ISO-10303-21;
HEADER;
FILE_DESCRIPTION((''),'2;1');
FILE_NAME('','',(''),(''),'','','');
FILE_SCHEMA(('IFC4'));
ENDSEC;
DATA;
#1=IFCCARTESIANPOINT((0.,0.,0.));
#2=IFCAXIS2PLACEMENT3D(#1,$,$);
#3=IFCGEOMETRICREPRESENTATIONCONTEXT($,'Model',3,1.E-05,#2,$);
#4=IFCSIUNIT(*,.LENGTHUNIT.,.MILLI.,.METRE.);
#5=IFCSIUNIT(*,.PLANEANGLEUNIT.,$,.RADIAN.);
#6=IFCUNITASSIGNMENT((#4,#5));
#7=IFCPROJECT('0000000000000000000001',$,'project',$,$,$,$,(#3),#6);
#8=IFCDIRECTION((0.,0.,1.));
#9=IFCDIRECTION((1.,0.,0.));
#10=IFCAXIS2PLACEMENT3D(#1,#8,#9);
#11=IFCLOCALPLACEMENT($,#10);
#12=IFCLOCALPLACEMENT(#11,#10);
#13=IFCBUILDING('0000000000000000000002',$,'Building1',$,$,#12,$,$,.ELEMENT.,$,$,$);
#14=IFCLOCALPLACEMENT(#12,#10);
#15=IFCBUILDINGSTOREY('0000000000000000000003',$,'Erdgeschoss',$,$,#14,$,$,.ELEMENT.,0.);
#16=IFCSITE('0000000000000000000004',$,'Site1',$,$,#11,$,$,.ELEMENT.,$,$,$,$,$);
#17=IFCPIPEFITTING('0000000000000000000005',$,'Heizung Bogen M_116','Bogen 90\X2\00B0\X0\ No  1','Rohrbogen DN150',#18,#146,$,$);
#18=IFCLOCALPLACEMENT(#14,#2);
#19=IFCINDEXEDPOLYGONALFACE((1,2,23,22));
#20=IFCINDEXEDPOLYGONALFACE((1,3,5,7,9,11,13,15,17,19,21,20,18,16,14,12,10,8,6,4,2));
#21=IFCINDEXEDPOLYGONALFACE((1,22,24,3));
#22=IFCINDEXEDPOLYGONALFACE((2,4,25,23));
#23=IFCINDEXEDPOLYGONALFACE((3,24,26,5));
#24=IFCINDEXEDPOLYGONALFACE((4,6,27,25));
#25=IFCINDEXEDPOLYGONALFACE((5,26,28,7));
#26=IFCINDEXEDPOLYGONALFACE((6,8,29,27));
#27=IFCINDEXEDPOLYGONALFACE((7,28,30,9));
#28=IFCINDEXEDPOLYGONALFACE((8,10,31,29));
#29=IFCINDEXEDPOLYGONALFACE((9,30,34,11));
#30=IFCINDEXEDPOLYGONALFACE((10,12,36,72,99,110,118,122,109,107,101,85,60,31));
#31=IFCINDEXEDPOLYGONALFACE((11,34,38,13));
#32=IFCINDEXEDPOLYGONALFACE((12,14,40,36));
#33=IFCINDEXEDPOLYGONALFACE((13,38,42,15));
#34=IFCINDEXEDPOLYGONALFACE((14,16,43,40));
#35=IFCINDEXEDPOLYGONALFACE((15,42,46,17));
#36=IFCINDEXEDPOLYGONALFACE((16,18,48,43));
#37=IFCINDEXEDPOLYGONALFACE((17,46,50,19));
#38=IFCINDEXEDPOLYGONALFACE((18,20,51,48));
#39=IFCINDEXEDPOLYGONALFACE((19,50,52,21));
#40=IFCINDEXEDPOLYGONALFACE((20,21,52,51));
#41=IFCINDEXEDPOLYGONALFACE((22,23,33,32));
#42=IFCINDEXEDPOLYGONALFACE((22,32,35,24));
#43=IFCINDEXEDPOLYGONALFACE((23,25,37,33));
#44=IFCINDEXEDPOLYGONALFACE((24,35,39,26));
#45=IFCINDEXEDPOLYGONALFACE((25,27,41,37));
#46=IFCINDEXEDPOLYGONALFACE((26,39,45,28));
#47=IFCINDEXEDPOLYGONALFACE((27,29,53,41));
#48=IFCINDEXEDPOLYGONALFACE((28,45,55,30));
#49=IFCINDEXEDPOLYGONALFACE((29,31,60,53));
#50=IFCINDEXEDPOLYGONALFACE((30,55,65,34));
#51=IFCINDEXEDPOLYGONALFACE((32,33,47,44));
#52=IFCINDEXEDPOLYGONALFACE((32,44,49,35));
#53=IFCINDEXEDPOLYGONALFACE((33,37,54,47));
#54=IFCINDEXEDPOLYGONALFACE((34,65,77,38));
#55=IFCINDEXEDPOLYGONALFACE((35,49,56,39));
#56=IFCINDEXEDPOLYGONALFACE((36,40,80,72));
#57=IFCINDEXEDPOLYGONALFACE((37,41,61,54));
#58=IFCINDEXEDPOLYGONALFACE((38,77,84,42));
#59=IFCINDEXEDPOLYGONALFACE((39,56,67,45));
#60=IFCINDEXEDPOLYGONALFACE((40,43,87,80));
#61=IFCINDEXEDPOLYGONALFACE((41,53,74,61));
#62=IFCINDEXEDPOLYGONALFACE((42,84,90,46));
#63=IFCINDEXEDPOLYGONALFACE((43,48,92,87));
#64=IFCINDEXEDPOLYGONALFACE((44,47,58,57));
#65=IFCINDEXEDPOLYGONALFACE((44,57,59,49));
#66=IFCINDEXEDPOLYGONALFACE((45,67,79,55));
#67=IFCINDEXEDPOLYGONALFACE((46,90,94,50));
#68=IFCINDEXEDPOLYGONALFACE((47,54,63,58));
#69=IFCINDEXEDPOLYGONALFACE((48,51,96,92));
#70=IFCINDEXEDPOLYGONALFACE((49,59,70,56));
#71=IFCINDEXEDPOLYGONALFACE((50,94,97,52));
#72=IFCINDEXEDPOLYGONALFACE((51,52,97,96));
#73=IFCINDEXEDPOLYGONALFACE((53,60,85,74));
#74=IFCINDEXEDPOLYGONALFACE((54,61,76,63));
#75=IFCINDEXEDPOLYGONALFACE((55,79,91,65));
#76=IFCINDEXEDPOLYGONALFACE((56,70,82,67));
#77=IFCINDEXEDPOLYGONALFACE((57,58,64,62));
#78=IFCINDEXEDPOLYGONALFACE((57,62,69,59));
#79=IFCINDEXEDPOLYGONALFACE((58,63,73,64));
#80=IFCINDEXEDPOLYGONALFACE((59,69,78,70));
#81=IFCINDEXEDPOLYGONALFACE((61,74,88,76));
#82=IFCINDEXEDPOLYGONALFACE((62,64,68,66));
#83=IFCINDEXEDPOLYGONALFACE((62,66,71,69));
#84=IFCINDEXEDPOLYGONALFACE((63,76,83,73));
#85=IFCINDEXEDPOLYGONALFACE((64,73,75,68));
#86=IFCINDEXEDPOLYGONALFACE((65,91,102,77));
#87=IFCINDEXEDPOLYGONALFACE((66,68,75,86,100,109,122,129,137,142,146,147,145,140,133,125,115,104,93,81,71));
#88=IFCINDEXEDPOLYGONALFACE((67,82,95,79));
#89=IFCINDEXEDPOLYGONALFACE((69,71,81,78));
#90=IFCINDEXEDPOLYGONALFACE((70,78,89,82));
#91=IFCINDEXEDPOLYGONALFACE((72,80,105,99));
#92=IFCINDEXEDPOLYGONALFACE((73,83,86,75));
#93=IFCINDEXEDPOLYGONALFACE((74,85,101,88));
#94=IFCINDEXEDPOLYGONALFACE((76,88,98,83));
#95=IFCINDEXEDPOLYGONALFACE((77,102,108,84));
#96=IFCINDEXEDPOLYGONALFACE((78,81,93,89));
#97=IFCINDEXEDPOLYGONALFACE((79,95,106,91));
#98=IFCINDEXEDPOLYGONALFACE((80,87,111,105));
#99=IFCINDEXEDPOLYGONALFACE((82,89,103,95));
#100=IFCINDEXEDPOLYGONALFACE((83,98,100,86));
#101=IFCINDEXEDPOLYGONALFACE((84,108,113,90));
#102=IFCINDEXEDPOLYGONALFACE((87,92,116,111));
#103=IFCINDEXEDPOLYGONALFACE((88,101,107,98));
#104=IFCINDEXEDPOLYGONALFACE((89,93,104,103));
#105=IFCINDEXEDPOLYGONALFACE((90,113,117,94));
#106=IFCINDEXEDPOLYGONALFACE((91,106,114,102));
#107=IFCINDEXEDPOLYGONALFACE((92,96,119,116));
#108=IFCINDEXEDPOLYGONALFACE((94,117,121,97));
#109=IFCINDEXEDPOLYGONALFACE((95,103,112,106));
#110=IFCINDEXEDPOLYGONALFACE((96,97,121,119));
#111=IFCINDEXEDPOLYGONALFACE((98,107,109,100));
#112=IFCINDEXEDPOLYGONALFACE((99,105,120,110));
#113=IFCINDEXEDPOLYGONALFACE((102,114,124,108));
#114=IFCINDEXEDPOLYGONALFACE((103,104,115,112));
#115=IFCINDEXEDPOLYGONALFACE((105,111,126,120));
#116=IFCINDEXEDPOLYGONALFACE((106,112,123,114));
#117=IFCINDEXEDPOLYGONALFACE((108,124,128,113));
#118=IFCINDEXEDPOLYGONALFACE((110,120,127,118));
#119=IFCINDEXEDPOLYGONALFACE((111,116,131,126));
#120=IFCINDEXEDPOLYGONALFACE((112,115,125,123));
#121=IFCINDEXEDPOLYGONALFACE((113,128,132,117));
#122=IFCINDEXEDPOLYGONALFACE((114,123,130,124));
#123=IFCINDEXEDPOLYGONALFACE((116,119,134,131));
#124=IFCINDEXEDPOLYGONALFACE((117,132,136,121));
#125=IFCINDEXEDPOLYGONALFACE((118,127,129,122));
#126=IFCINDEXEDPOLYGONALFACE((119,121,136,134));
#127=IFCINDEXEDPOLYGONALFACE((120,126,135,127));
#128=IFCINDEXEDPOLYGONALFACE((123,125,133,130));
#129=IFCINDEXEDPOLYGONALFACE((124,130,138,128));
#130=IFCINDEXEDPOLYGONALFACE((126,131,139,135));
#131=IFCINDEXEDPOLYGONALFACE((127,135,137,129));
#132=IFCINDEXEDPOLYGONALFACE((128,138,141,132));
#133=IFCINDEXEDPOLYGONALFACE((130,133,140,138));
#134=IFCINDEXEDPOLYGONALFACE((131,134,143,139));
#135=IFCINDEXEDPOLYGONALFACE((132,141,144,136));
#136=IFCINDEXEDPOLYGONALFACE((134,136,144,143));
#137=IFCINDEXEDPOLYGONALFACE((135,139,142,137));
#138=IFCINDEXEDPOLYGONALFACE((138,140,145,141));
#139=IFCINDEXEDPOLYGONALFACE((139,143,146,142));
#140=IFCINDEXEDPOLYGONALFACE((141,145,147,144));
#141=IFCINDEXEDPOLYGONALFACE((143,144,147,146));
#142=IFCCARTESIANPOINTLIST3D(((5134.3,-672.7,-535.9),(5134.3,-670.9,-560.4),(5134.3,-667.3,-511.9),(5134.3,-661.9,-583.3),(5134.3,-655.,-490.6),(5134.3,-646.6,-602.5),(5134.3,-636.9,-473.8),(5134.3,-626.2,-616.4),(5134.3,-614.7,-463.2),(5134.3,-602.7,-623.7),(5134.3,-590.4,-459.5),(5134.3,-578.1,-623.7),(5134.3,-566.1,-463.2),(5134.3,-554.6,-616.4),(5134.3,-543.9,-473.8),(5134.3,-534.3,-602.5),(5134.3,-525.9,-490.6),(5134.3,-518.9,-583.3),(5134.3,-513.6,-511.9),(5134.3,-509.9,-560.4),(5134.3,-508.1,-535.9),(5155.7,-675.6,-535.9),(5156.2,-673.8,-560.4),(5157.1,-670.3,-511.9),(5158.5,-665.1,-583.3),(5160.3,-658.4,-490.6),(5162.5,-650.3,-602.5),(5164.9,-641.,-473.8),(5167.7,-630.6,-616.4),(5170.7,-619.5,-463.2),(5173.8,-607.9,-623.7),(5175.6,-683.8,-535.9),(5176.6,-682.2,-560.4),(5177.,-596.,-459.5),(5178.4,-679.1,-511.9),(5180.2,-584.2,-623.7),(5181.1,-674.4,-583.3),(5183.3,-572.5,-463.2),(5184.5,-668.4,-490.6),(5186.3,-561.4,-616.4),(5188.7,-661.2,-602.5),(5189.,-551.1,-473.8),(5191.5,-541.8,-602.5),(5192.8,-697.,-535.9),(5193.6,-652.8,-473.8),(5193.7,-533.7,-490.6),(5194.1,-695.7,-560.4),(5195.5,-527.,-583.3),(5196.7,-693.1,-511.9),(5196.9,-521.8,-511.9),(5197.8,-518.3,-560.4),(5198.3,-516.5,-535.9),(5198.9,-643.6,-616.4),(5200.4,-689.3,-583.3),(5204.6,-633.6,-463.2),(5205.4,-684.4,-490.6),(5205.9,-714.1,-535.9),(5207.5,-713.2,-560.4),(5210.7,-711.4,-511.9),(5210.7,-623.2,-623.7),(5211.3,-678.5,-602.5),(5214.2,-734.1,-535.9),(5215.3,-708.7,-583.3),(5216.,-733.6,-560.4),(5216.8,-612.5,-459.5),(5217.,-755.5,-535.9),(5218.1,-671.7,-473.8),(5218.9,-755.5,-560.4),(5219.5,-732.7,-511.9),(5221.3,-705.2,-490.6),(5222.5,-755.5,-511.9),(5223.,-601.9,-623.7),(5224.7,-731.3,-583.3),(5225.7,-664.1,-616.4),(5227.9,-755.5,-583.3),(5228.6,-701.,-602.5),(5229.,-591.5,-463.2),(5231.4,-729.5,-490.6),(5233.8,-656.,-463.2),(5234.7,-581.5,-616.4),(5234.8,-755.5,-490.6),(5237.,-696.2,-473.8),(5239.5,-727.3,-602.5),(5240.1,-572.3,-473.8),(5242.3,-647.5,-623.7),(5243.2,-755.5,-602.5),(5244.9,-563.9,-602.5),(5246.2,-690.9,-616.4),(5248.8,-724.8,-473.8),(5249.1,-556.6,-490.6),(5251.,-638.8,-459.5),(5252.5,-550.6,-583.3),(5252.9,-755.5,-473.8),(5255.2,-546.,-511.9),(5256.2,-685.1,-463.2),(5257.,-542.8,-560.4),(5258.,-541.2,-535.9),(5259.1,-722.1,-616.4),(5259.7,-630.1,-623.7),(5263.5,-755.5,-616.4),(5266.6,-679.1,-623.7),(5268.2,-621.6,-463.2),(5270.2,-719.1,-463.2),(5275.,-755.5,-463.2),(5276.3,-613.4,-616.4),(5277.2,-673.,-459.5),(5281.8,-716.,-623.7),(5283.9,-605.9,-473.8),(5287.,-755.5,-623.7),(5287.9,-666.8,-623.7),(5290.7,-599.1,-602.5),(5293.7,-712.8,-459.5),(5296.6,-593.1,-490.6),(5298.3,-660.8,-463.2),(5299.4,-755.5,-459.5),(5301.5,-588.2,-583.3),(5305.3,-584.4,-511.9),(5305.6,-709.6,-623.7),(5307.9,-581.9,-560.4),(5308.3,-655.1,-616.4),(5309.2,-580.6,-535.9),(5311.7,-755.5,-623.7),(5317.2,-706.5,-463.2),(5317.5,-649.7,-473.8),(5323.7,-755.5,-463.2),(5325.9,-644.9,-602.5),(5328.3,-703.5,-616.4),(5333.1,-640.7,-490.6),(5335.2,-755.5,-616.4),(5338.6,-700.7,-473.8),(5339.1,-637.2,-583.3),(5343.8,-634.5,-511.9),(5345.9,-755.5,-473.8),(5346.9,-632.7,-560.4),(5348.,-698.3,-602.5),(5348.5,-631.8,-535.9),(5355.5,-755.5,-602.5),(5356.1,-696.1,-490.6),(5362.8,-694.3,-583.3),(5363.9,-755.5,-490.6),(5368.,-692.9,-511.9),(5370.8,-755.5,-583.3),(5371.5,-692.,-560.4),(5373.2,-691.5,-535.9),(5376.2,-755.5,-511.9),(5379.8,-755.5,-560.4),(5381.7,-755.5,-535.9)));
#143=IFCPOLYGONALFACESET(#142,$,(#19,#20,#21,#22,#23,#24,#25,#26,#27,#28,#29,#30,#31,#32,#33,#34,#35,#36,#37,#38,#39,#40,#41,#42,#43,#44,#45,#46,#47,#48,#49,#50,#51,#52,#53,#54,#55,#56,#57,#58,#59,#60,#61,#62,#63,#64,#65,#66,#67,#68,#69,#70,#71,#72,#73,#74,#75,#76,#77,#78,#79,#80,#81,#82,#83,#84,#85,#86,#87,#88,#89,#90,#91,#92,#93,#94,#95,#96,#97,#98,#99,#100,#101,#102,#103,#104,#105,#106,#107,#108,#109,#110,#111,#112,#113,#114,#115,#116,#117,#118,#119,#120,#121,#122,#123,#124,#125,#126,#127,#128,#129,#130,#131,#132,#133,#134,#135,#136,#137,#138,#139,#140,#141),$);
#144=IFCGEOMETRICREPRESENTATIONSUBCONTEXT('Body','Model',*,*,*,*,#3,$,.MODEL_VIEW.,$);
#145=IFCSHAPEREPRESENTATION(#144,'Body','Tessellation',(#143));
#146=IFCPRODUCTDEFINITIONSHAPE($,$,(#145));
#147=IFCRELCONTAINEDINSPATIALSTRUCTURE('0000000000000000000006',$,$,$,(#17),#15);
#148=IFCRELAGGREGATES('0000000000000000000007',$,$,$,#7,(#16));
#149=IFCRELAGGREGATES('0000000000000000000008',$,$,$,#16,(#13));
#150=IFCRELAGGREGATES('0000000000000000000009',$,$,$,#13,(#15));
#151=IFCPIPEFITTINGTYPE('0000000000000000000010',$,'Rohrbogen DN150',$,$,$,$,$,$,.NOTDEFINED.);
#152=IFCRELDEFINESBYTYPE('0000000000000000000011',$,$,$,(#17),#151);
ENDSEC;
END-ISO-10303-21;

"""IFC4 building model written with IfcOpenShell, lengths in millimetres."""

from ifc_helpers import new_model, entity, si_unit, frame, origin, origin_with_axes, place, context, subcontext, project, spatial, source, transform, mapped, type_object, element, save


model = new_model("IFC4")

# Units and contexts
model_context = context("Model", 3, precision=1e-05, world=origin())
body_context = subcontext(model_context, "Body", "Model", "MODEL_VIEW")
ifc_project = project(units=[si_unit("LENGTHUNIT", "METRE", prefix="MILLI"), si_unit("PLANEANGLEUNIT", "RADIAN")], contexts=[model_context])

# Site, building, storey
site_placement = place(None, origin_with_axes())
site = spatial("IfcSite", under=ifc_project, at=site_placement, Name="Site1", CompositionType="ELEMENT")
building_placement = place(site_placement, origin_with_axes())
building = spatial("IfcBuilding", under=site, at=building_placement, Name="Building1", CompositionType="ELEMENT")
storey_placement = place(building_placement, origin_with_axes())
storey = spatial("IfcBuildingStorey", under=building, at=storey_placement, Name="Erdgeschoss", CompositionType="ELEMENT", Elevation=0.0)

# Pipe fitting
pipe_fitting_type_1 = type_object("IfcPipeFittingType", Name="Rohrbogen DN150", PredefinedType="NOTDEFINED")
shared_shape_1 = source(origin_with_axes(), body_context, "Body", "SolidModel", [
    entity("IfcRevolvedAreaSolid", entity("IfcCircleProfileDef", "AREA", None, entity("IfcAxis2Placement2D", entity("IfcCartesianPoint", [0.0, 0.0]), entity("IfcDirection", [1.0, 0.0])), 82.5), entity("IfcAxis2Placement3D", entity("IfcCartesianPoint", [-123.8, 41.3, 0.0]), entity("IfcDirection", [1.0, 0.0, 0.0]), entity("IfcDirection", [0.0, 0.0, 1.0])), entity("IfcAxis1Placement", entity("IfcCartesianPoint", [0.0, 165.1, 0.0]), entity("IfcDirection", [-1.0, 0.0, 0.0])), 1.570796),
])
pipe_fitting_1_placement = place(storey_placement, frame((5258.1, -631.7, -542.0), z_axis=(0.0, 0.0, 1.0), x_axis=(1.0, 0.0, 0.0)))
element("IfcPipeFitting", 1, at=pipe_fitting_1_placement, inside=storey, type_object=pipe_fitting_type_1, Name="Heizung Bogen M_116", Description="Bogen 90° No  1", ObjectType="Rohrbogen DN150", context=body_context, shape_type="MappedRepresentation", body=[
    mapped(shared_shape_1, transform((0.0, 0.0, 0.0), x_axis=(1.0, 0.0, 0.0), y_axis=(0.0, 1.0, 0.0), z_axis=(0.0, 0.0, 1.0), scale=1.0)),
])

save(model, "model.ifc")
